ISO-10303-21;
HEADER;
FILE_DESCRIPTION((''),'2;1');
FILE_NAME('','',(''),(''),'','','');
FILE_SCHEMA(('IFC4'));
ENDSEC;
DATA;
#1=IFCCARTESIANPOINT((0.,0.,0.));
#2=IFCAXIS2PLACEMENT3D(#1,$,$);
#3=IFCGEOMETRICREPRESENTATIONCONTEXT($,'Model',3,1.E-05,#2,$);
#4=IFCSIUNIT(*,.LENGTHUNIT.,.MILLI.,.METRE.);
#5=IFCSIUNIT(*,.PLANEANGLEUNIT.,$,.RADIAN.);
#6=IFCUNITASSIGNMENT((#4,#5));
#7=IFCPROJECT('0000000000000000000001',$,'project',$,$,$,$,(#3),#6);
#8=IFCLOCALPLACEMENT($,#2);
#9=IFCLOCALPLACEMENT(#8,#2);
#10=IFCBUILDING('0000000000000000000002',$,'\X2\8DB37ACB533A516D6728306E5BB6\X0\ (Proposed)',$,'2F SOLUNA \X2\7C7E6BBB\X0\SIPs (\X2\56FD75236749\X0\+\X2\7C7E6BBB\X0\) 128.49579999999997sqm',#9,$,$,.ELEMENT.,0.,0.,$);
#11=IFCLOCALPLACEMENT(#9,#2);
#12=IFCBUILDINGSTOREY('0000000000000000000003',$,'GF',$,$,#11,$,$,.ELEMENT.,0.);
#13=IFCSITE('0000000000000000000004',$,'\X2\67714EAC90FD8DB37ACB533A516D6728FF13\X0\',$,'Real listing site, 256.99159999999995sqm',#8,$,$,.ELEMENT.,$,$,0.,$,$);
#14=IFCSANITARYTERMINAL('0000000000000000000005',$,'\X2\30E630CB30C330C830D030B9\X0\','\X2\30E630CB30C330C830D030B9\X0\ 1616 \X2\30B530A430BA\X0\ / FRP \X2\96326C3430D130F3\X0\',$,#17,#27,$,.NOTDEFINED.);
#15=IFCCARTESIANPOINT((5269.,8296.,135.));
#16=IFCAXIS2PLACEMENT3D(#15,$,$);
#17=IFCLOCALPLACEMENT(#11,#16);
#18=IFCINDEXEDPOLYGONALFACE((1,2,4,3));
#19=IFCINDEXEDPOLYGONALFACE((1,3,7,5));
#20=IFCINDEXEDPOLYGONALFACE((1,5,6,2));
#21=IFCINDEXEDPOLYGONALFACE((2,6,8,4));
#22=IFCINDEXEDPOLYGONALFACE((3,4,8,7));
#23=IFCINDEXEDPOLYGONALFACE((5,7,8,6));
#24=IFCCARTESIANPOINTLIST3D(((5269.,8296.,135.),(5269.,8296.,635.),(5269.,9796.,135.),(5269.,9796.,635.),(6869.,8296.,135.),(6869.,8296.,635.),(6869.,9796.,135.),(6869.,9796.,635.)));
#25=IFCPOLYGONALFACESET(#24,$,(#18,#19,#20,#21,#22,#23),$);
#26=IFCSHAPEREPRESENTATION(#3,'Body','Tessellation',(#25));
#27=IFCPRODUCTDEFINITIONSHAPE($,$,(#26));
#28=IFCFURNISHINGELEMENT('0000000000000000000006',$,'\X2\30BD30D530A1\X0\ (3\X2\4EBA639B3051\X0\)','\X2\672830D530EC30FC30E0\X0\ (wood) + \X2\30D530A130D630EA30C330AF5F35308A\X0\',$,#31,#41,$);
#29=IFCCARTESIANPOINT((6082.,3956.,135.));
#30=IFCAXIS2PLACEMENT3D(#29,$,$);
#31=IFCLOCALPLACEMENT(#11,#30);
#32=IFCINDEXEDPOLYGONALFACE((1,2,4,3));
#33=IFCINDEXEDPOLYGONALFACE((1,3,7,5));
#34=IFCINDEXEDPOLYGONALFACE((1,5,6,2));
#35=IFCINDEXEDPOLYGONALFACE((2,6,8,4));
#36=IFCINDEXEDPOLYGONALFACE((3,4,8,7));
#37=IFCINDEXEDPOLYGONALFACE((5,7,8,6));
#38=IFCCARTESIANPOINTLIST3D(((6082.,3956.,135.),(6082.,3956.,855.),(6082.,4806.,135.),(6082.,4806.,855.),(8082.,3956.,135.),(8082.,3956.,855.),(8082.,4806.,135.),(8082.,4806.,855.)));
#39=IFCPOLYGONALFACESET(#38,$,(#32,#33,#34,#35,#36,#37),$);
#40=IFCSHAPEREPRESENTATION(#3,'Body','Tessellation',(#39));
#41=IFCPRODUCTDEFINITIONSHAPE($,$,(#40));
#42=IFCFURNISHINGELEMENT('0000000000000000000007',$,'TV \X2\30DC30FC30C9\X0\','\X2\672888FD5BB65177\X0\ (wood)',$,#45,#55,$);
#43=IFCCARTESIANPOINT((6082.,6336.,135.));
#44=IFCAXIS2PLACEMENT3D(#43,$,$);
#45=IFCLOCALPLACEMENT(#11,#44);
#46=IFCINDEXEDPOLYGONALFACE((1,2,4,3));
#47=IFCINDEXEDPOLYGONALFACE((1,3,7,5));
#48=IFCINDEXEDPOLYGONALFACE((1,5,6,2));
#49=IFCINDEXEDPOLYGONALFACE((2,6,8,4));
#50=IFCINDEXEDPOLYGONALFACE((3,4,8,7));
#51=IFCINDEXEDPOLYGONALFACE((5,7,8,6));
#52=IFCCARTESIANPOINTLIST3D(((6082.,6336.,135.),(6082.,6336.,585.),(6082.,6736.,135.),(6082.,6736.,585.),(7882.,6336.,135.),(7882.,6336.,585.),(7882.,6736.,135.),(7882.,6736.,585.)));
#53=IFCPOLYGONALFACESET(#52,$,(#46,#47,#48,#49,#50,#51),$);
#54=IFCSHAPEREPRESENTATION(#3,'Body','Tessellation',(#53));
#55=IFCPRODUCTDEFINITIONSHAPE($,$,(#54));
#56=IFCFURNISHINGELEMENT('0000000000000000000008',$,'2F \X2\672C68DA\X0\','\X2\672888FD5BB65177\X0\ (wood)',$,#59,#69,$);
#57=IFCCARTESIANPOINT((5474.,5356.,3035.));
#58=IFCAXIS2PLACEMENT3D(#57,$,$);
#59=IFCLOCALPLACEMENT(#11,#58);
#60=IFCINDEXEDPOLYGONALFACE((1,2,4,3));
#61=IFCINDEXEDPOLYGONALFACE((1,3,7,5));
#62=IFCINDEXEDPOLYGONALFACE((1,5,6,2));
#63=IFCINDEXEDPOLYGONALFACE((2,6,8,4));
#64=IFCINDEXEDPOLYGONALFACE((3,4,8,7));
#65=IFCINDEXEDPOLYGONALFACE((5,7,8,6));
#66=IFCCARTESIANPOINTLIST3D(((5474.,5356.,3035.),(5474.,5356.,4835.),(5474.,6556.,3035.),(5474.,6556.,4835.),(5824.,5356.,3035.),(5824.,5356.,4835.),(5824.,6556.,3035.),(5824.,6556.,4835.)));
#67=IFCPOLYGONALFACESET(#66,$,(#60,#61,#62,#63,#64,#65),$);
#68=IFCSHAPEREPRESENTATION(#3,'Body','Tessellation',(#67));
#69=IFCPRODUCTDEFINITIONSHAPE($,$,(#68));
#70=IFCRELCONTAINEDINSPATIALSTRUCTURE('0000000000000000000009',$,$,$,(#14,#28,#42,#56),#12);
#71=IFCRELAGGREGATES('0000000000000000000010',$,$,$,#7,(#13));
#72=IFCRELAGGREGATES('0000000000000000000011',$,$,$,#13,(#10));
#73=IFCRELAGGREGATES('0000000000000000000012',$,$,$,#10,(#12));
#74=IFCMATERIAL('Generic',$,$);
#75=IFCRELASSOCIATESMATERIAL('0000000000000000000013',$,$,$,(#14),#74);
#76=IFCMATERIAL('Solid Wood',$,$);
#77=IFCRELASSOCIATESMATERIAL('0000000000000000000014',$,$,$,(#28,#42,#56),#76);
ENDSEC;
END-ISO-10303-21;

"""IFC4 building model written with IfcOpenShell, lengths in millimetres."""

from ifc_helpers import new_model, si_unit, frame, frame_2d, origin, place, context, project, spatial, rectangle, extrude, material, element, save


model = new_model("IFC4")

# Units and contexts
model_context = context("Model", 3, precision=1e-05, world=origin())
ifc_project = project(units=[si_unit("LENGTHUNIT", "METRE", prefix="MILLI"), si_unit("PLANEANGLEUNIT", "RADIAN")], contexts=[model_context])

# Site, building, storey
site_placement = place(None, origin())
site = spatial("IfcSite", under=ifc_project, at=site_placement, Name="東京都足立区六木３", ObjectType="Real listing site, 256.99159999999995sqm", CompositionType="ELEMENT", RefElevation=0.0)
building_placement = place(site_placement, origin())
building = spatial("IfcBuilding", under=site, at=building_placement, Name="足立区六木の家 (Proposed)", ObjectType="2F SOLUNA 籾殻SIPs (国産杉+籾殻) 128.49579999999997sqm", CompositionType="ELEMENT", ElevationOfRefHeight=0.0, ElevationOfTerrain=0.0)
storey_placement = place(building_placement, origin())
storey = spatial("IfcBuildingStorey", under=building, at=storey_placement, Name="GF", CompositionType="ELEMENT", Elevation=0.0)

# Shared definitions
ifc_material_1 = material(Name="Solid Wood")

# Sanitary terminal
ifc_material_2 = material(Name="Generic")
sanitary_terminal_placement = place(storey_placement, frame((5269.0, 8296.0, 135.0)))
element("IfcSanitaryTerminal", 1, at=sanitary_terminal_placement, inside=storey, material=ifc_material_2, Name="ユニットバス", Description="ユニットバス 1616 サイズ / FRP 防水パン", PredefinedType="NOTDEFINED", context=model_context, shape_type="SweptSolid", body=[
    extrude(rectangle(XDim=1600.0, YDim=1500.0, at=frame_2d((800.0, 750.0))), frame((5269.0, 8296.0, 135.0)), (0.0, 0.0, 1.0), 500.0),
])

# Furnishing elements
furnishing_1_placement = place(storey_placement, frame((6082.0, 3956.0, 135.0)))
element("IfcFurnishingElement", 2, at=furnishing_1_placement, inside=storey, material=ifc_material_1, Name="ソファ (3人掛け)", Description="木フレーム (wood) + ファブリック張り", context=model_context, shape_type="SweptSolid", body=[
    extrude(rectangle(XDim=2000.0, YDim=850.0, at=frame_2d((1000.0, 425.0))), frame((6082.0, 3956.0, 135.0)), (0.0, 0.0, 1.0), 720.0),
])
furnishing_2_placement = place(storey_placement, frame((6082.0, 6336.0, 135.0)))
element("IfcFurnishingElement", 3, at=furnishing_2_placement, inside=storey, material=ifc_material_1, Name="TV ボード", Description="木製家具 (wood)", context=model_context, shape_type="SweptSolid", body=[
    extrude(rectangle(XDim=1800.0, YDim=400.0, at=frame_2d((900.0, 200.0))), frame((6082.0, 6336.0, 135.0)), (0.0, 0.0, 1.0), 450.0),
])
furnishing_3_placement = place(storey_placement, frame((5474.0, 5356.0, 3035.0)))
element("IfcFurnishingElement", 4, at=furnishing_3_placement, inside=storey, material=ifc_material_1, Name="2F 本棚", Description="木製家具 (wood)", context=model_context, shape_type="SweptSolid", body=[
    extrude(rectangle(XDim=350.0, YDim=1200.0, at=frame_2d((175.0, 600.0))), frame((5474.0, 5356.0, 3035.0)), (0.0, 0.0, 1.0), 1800.0),
])

save(model, "model.ifc")
